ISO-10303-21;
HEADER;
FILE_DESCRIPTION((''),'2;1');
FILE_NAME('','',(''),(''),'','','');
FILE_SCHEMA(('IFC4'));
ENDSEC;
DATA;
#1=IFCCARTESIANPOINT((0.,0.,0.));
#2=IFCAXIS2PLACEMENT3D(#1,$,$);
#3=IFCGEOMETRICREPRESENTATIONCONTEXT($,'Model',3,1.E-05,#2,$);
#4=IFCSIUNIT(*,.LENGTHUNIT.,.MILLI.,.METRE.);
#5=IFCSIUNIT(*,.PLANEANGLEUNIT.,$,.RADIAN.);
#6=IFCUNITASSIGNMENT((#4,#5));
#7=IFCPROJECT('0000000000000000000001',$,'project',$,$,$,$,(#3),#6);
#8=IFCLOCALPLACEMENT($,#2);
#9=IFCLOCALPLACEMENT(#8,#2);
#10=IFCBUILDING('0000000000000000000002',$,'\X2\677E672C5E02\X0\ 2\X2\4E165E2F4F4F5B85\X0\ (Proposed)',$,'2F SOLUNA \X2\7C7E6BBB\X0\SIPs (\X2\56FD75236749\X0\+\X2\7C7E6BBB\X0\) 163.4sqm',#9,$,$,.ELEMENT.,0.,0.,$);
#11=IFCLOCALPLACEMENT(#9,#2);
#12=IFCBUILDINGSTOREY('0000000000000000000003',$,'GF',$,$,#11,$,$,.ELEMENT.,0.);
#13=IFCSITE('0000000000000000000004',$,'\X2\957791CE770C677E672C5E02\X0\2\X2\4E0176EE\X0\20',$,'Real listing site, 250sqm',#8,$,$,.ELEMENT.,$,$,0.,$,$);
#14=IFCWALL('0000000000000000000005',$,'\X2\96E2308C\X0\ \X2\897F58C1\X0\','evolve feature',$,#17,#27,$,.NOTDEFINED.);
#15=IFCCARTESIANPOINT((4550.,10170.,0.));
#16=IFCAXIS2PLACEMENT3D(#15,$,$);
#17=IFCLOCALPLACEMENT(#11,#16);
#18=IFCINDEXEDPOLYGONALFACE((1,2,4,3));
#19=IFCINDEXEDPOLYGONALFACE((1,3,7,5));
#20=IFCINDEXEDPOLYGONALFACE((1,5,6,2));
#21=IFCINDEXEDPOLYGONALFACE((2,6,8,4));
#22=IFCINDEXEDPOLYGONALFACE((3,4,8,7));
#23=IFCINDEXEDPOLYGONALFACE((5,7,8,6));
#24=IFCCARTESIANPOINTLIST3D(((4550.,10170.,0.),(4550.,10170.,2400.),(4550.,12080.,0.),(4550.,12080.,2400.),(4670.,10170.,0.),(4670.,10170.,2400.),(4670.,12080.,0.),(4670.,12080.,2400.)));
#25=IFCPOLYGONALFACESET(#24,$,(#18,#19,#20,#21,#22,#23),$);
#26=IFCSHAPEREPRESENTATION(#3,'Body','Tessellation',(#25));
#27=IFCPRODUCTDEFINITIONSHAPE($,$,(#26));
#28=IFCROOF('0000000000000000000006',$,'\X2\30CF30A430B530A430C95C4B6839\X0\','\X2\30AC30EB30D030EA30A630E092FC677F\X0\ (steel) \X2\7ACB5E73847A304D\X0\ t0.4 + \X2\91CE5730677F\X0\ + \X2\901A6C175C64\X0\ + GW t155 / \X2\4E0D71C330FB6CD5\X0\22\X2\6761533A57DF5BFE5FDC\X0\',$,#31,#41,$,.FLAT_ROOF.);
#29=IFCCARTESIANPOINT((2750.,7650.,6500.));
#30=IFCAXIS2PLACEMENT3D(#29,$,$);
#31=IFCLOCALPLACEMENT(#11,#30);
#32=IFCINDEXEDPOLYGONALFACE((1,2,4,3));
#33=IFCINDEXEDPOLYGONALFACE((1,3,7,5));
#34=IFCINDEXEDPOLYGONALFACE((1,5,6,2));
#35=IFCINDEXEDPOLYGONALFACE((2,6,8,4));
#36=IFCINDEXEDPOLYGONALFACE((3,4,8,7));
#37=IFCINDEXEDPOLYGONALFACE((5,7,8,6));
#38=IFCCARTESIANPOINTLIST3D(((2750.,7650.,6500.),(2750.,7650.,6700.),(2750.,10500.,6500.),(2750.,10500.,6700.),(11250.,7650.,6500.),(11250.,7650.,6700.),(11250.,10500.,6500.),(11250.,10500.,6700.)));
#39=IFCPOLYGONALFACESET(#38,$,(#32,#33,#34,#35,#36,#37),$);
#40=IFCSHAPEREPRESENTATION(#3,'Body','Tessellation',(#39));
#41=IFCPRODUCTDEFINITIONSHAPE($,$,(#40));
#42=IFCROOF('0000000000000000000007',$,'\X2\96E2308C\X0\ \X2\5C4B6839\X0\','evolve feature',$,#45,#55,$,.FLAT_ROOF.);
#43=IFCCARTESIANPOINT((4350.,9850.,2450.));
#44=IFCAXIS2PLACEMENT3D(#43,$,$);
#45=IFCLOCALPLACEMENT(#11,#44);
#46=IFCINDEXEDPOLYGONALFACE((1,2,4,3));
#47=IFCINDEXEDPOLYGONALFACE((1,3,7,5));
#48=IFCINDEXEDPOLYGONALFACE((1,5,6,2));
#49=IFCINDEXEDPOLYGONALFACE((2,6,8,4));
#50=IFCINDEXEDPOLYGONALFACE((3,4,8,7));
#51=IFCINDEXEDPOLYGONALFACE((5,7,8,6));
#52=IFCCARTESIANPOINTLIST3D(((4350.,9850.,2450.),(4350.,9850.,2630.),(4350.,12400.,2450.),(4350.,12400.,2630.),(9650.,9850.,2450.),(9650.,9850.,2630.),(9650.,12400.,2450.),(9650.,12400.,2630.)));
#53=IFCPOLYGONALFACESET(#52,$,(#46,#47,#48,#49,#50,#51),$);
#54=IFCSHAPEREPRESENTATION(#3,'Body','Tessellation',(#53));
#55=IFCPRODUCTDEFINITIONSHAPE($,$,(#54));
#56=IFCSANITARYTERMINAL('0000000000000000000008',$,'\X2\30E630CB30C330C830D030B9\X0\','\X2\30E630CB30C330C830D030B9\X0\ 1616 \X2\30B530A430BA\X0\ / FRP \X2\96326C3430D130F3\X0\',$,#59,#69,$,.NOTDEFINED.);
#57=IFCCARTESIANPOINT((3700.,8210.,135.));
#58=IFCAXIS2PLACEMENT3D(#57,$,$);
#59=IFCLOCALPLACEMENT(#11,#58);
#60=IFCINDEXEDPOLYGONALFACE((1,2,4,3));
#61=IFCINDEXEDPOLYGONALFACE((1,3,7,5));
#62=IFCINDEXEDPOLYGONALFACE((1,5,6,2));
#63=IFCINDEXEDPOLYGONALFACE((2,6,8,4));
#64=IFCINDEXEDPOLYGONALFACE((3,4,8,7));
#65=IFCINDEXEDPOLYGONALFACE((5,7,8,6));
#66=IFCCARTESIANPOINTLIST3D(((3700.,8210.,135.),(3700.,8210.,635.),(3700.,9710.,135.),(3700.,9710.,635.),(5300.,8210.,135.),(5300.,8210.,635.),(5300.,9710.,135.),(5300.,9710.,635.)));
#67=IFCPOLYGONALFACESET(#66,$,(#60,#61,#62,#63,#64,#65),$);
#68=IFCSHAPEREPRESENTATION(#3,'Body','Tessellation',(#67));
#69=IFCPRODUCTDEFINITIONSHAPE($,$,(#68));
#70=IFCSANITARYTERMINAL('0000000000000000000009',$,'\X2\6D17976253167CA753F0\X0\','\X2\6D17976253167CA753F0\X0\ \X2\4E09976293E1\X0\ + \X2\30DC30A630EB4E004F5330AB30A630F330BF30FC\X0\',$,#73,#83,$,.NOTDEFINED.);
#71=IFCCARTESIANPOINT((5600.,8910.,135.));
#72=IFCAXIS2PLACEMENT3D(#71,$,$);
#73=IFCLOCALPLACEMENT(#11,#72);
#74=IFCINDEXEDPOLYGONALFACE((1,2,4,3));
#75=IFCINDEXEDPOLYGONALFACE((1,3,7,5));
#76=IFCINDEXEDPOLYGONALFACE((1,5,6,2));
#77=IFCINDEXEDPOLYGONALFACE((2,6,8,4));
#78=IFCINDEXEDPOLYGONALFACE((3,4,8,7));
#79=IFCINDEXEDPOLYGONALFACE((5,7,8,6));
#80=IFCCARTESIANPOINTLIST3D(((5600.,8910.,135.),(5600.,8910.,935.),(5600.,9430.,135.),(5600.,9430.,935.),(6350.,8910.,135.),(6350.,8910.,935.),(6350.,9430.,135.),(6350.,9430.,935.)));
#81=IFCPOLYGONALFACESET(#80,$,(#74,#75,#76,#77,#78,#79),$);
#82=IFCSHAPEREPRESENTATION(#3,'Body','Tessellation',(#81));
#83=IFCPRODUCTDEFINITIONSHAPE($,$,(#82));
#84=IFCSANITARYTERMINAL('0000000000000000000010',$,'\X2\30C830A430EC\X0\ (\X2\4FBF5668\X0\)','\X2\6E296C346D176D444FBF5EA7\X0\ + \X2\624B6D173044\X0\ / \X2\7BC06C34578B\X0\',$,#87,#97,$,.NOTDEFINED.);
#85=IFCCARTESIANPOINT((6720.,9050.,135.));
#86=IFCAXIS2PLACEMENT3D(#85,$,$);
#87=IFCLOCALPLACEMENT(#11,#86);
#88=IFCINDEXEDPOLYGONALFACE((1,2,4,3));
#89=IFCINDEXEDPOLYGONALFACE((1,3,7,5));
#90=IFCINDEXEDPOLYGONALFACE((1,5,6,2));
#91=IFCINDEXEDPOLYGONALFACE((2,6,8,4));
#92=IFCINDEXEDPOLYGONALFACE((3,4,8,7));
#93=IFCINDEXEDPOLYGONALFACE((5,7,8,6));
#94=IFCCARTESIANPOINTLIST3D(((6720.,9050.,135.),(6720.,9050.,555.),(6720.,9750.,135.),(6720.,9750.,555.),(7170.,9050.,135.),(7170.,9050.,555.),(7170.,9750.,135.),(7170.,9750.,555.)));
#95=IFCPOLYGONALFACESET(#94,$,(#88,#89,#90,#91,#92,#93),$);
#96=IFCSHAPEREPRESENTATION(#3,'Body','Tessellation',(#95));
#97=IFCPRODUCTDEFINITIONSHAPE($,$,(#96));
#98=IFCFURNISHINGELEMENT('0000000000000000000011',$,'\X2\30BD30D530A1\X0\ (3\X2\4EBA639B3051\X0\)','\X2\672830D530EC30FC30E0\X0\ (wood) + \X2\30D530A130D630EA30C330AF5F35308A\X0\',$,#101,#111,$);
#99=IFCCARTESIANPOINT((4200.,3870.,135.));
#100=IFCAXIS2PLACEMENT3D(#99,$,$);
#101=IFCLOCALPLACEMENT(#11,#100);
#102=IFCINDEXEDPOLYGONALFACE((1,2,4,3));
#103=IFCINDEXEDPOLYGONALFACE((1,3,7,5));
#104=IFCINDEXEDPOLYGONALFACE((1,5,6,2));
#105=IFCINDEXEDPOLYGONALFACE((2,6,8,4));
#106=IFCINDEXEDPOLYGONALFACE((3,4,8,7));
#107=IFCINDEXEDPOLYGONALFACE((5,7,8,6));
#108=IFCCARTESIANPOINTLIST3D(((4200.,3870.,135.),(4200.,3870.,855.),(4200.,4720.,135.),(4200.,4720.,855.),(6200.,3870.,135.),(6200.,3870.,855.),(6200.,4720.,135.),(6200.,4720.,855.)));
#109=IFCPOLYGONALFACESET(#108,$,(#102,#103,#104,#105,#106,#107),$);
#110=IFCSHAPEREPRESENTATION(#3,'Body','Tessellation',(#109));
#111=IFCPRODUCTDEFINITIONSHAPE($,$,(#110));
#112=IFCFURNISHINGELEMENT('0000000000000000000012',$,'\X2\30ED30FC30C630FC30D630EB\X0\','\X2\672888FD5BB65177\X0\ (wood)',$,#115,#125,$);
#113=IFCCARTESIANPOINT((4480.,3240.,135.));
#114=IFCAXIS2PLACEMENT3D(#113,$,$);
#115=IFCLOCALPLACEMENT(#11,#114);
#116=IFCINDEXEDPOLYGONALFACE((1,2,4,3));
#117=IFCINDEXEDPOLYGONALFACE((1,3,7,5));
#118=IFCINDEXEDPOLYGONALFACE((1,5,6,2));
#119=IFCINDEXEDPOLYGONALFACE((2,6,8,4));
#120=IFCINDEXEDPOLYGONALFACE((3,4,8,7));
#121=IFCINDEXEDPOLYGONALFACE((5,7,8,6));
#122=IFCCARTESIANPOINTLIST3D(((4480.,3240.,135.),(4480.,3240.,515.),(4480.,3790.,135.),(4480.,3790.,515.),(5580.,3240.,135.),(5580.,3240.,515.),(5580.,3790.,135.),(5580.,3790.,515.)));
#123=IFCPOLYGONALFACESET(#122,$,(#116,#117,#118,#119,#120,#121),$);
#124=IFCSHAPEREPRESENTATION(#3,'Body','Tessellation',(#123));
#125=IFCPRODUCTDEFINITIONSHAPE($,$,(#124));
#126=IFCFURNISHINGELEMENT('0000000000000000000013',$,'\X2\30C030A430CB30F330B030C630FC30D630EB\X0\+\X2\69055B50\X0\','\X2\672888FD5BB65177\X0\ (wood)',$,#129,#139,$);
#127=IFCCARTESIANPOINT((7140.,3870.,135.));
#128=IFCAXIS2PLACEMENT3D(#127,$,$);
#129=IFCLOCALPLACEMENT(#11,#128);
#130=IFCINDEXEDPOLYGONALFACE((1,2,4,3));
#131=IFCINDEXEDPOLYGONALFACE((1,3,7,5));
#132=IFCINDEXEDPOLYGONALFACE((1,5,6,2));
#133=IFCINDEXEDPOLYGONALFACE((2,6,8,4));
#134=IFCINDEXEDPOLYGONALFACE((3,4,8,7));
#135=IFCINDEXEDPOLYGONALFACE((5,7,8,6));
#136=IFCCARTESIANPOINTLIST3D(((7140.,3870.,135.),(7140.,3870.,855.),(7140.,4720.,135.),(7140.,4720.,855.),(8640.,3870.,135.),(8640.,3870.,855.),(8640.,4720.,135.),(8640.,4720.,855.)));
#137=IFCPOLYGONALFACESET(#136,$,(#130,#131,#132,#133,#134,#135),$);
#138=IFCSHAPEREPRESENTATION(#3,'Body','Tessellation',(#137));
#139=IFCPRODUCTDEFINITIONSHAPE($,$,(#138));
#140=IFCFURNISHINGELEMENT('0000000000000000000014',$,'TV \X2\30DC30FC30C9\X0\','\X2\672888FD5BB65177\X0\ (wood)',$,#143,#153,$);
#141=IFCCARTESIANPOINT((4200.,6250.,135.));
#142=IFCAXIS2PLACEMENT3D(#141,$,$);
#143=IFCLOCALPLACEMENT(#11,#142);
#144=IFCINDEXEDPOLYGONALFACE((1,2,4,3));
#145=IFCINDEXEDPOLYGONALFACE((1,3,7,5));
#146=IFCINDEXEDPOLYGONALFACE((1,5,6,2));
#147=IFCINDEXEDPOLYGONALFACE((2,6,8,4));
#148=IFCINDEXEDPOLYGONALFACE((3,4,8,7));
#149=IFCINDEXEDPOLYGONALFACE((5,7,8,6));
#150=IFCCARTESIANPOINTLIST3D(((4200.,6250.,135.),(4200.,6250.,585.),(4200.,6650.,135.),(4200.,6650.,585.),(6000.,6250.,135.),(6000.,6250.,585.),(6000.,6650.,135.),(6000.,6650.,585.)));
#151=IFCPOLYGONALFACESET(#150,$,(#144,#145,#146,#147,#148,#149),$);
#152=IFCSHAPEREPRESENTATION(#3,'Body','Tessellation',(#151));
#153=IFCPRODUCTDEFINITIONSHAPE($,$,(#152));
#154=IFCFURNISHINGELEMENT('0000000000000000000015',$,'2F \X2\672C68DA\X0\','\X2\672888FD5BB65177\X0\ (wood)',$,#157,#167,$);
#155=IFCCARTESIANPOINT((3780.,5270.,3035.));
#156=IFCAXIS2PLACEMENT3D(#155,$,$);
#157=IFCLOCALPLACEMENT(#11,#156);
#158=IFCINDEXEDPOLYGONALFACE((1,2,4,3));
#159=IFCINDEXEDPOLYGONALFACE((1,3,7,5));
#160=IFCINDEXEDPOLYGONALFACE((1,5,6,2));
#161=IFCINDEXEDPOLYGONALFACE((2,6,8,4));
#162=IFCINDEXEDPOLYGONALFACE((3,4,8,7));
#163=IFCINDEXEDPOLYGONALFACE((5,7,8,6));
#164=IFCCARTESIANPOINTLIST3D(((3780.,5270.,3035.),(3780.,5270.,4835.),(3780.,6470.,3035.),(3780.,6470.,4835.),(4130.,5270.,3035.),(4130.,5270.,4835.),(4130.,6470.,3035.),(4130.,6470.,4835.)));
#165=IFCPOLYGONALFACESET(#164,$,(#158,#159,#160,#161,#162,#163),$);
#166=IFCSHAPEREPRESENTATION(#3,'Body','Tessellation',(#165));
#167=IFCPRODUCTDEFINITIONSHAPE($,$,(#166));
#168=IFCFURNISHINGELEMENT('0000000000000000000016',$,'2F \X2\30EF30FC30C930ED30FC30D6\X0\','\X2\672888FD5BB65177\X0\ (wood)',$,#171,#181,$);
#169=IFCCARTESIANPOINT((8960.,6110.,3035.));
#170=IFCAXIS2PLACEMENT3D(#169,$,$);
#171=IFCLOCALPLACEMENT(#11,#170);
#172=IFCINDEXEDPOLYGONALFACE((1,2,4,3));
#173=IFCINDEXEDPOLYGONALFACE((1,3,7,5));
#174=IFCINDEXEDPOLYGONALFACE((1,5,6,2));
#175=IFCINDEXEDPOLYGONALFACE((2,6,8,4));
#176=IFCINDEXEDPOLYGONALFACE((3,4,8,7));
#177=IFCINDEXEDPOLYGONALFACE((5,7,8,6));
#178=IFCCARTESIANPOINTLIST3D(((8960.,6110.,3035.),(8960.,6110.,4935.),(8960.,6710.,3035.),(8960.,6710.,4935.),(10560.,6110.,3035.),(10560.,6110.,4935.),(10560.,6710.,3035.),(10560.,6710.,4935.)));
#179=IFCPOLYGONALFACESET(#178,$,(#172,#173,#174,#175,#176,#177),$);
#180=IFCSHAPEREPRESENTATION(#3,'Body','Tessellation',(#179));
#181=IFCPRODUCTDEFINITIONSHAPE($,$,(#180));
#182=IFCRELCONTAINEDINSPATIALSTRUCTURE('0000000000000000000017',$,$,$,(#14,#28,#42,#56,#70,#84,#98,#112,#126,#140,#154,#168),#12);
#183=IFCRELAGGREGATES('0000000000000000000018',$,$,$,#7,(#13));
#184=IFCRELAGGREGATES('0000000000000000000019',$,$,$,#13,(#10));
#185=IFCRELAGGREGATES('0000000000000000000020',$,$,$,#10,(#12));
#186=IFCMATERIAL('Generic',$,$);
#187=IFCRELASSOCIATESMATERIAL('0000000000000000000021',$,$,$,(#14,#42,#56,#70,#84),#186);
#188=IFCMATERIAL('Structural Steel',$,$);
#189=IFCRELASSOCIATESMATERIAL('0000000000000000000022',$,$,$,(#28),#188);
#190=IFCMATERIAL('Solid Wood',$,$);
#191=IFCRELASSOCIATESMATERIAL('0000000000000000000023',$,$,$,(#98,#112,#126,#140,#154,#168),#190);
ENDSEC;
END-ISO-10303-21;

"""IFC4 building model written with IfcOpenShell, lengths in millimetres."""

from ifc_helpers import new_model, si_unit, frame, frame_2d, origin, place, context, project, spatial, rectangle, extrude, material, element, save


model = new_model("IFC4")

# Units and contexts
model_context = context("Model", 3, precision=1e-05, world=origin())
ifc_project = project(units=[si_unit("LENGTHUNIT", "METRE", prefix="MILLI"), si_unit("PLANEANGLEUNIT", "RADIAN")], contexts=[model_context])

# Site, building, storey
site_placement = place(None, origin())
site = spatial("IfcSite", under=ifc_project, at=site_placement, Name="長野県松本市2丁目20", ObjectType="Real listing site, 250sqm", CompositionType="ELEMENT", RefElevation=0.0)
building_placement = place(site_placement, origin())
building = spatial("IfcBuilding", under=site, at=building_placement, Name="松本市 2世帯住宅 (Proposed)", ObjectType="2F SOLUNA 籾殻SIPs (国産杉+籾殻) 163.4sqm", CompositionType="ELEMENT", ElevationOfRefHeight=0.0, ElevationOfTerrain=0.0)
storey_placement = place(building_placement, origin())
storey = spatial("IfcBuildingStorey", under=building, at=storey_placement, Name="GF", CompositionType="ELEMENT", Elevation=0.0)

# Shared definitions
ifc_material_1 = material(Name="Generic")

# Shared definitions
ifc_material_2 = material(Name="Solid Wood")

# Wall
wall_1_placement = place(storey_placement, frame((4550.0, 10170.0, 0.0)))
element("IfcWall", 1, at=wall_1_placement, inside=storey, material=ifc_material_1, Name="離れ 西壁", Description="evolve feature", PredefinedType="NOTDEFINED", context=model_context, shape_type="SweptSolid", body=[
    extrude(rectangle(XDim=120.0, YDim=1910.0, at=frame_2d((60.0, 955.0))), frame((4550.0, 10170.0, 0.0)), (0.0, 0.0, 1.0), 2400.0),
])

# Roofs
ifc_material_3 = material(Name="Structural Steel")
roof_1_placement = place(storey_placement, frame((2750.0, 7650.0, 6500.0)))
element("IfcRoof", 2, at=roof_1_placement, inside=storey, material=ifc_material_3, Name="ハイサイド屋根", Description="ガルバリウム鋼板 (steel) 立平葺き t0.4 + 野地板 + 通気層 + GW t155 / 不燃・法22条区域対応", PredefinedType="FLAT_ROOF", context=model_context, shape_type="SweptSolid", body=[
    extrude(rectangle(XDim=8500.0, YDim=2850.0, at=frame_2d((4250.0, 1425.0))), frame((2750.0, 7650.0, 6500.0)), (0.0, 0.0, 1.0), 200.0),
])
roof_2_placement = place(storey_placement, frame((4350.0, 9850.0, 2450.0)))
element("IfcRoof", 3, at=roof_2_placement, inside=storey, material=ifc_material_1, Name="離れ 屋根", Description="evolve feature", PredefinedType="FLAT_ROOF", context=model_context, shape_type="SweptSolid", body=[
    extrude(rectangle(XDim=5300.0, YDim=2550.0, at=frame_2d((2650.0, 1275.0))), frame((4350.0, 9850.0, 2450.0)), (0.0, 0.0, 1.0), 180.0),
])

# Sanitary terminals
sanitary_terminal_1_placement = place(storey_placement, frame((3700.0, 8210.0, 135.0)))
element("IfcSanitaryTerminal", 4, at=sanitary_terminal_1_placement, inside=storey, material=ifc_material_1, Name="ユニットバス", Description="ユニットバス 1616 サイズ / FRP 防水パン", PredefinedType="NOTDEFINED", context=model_context, shape_type="SweptSolid", body=[
    extrude(rectangle(XDim=1600.0, YDim=1500.0, at=frame_2d((800.0, 750.0))), frame((3700.0, 8210.0, 135.0)), (0.0, 0.0, 1.0), 500.0),
])
sanitary_terminal_2_placement = place(storey_placement, frame((5600.0, 8910.0, 135.0)))
element("IfcSanitaryTerminal", 5, at=sanitary_terminal_2_placement, inside=storey, material=ifc_material_1, Name="洗面化粧台", Description="洗面化粧台 三面鏡 + ボウル一体カウンター", PredefinedType="NOTDEFINED", context=model_context, shape_type="SweptSolid", body=[
    extrude(rectangle(XDim=750.0, YDim=520.0, at=frame_2d((375.0, 260.0))), frame((5600.0, 8910.0, 135.0)), (0.0, 0.0, 1.0), 800.0),
])
sanitary_terminal_3_placement = place(storey_placement, frame((6720.0, 9050.0, 135.0)))
element("IfcSanitaryTerminal", 6, at=sanitary_terminal_3_placement, inside=storey, material=ifc_material_1, Name="トイレ (便器)", Description="温水洗浄便座 + 手洗い / 節水型", PredefinedType="NOTDEFINED", context=model_context, shape_type="SweptSolid", body=[
    extrude(rectangle(XDim=450.0, YDim=700.0, at=frame_2d((225.0, 350.0))), frame((6720.0, 9050.0, 135.0)), (0.0, 0.0, 1.0), 420.0),
])

# Furnishing elements
furnishing_1_placement = place(storey_placement, frame((4200.0, 3870.0, 135.0)))
element("IfcFurnishingElement", 7, at=furnishing_1_placement, inside=storey, material=ifc_material_2, Name="ソファ (3人掛け)", Description="木フレーム (wood) + ファブリック張り", context=model_context, shape_type="SweptSolid", body=[
    extrude(rectangle(XDim=2000.0, YDim=850.0, at=frame_2d((1000.0, 425.0))), frame((4200.0, 3870.0, 135.0)), (0.0, 0.0, 1.0), 720.0),
])
furnishing_2_placement = place(storey_placement, frame((4480.0, 3240.0, 135.0)))
element("IfcFurnishingElement", 8, at=furnishing_2_placement, inside=storey, material=ifc_material_2, Name="ローテーブル", Description="木製家具 (wood)", context=model_context, shape_type="SweptSolid", body=[
    extrude(rectangle(XDim=1100.0, YDim=550.0, at=frame_2d((550.0, 275.0))), frame((4480.0, 3240.0, 135.0)), (0.0, 0.0, 1.0), 380.0),
])
furnishing_3_placement = place(storey_placement, frame((7140.0, 3870.0, 135.0)))
element("IfcFurnishingElement", 9, at=furnishing_3_placement, inside=storey, material=ifc_material_2, Name="ダイニングテーブル+椅子", Description="木製家具 (wood)", context=model_context, shape_type="SweptSolid", body=[
    extrude(rectangle(XDim=1500.0, YDim=850.0, at=frame_2d((750.0, 425.0))), frame((7140.0, 3870.0, 135.0)), (0.0, 0.0, 1.0), 720.0),
])
furnishing_4_placement = place(storey_placement, frame((4200.0, 6250.0, 135.0)))
element("IfcFurnishingElement", 10, at=furnishing_4_placement, inside=storey, material=ifc_material_2, Name="TV ボード", Description="木製家具 (wood)", context=model_context, shape_type="SweptSolid", body=[
    extrude(rectangle(XDim=1800.0, YDim=400.0, at=frame_2d((900.0, 200.0))), frame((4200.0, 6250.0, 135.0)), (0.0, 0.0, 1.0), 450.0),
])
furnishing_5_placement = place(storey_placement, frame((3780.0, 5270.0, 3035.0)))
element("IfcFurnishingElement", 11, at=furnishing_5_placement, inside=storey, material=ifc_material_2, Name="2F 本棚", Description="木製家具 (wood)", context=model_context, shape_type="SweptSolid", body=[
    extrude(rectangle(XDim=350.0, YDim=1200.0, at=frame_2d((175.0, 600.0))), frame((3780.0, 5270.0, 3035.0)), (0.0, 0.0, 1.0), 1800.0),
])
furnishing_6_placement = place(storey_placement, frame((8960.0, 6110.0, 3035.0)))
element("IfcFurnishingElement", 12, at=furnishing_6_placement, inside=storey, material=ifc_material_2, Name="2F ワードローブ", Description="木製家具 (wood)", context=model_context, shape_type="SweptSolid", body=[
    extrude(rectangle(XDim=1600.0, YDim=600.0, at=frame_2d((800.0, 300.0))), frame((8960.0, 6110.0, 3035.0)), (0.0, 0.0, 1.0), 1900.0),
])

save(model, "model.ifc")
